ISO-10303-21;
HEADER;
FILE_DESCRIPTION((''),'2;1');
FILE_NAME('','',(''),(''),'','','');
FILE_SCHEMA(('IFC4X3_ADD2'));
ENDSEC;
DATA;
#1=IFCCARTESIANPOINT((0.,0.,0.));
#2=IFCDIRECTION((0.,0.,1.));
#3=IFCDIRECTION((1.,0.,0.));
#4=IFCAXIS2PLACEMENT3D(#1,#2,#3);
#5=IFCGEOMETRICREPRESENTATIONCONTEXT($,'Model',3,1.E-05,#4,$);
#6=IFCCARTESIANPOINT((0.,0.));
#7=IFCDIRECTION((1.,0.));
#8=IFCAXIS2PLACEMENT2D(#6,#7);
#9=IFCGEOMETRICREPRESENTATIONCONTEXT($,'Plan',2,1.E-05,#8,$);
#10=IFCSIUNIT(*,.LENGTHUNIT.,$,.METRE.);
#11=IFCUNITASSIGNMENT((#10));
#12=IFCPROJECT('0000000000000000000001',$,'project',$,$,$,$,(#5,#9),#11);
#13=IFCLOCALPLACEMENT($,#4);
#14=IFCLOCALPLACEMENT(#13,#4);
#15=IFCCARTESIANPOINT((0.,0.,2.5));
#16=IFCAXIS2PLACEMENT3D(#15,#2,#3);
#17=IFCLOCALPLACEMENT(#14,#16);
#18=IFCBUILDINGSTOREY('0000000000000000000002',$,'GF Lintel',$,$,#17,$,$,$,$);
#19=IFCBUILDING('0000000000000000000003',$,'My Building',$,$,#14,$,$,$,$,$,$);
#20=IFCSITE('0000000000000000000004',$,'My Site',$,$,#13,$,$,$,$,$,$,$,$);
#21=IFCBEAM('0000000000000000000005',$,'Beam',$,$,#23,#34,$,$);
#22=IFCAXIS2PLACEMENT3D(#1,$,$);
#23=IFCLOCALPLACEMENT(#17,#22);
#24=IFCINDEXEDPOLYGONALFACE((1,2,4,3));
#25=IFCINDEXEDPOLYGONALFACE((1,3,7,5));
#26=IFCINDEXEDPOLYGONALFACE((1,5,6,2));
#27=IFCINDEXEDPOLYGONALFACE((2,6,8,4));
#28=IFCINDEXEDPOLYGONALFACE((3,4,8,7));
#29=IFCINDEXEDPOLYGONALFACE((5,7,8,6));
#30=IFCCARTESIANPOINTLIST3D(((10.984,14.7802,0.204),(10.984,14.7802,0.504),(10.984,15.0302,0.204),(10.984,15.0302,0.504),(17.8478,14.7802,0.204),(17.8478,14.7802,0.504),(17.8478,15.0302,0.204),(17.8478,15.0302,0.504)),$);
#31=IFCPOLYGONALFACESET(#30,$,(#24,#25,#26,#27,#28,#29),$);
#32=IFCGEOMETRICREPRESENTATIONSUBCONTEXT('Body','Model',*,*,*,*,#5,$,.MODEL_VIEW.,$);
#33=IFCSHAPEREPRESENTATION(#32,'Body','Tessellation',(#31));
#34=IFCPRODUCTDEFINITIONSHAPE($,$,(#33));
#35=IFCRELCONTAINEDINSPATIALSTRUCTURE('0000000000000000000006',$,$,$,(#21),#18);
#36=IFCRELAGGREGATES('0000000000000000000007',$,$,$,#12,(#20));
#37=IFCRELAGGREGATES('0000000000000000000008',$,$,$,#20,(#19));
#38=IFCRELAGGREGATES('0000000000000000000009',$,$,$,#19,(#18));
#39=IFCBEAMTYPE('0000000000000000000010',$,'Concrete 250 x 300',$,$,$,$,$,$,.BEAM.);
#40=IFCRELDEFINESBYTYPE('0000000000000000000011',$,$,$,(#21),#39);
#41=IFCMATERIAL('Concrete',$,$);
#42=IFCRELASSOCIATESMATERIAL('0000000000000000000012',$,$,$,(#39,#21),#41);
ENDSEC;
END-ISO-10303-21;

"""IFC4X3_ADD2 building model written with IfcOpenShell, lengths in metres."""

from ifc_helpers import new_model, si_unit, frame, origin_with_axes, origin_2d_with_axis, place, context, subcontext, project, spatial, rectangle, extrude, material, material_profile, profile_set, profile_usage, type_object, element, save


model = new_model("IFC4X3_ADD2")

# Units and contexts
model_context = context("Model", 3, precision=1e-05, world=origin_with_axes())
plan_context = context("Plan", 2, precision=1e-05, world=origin_2d_with_axis())
body_context = subcontext(model_context, "Body", "Model", "MODEL_VIEW")
ifc_project = project(units=[si_unit("LENGTHUNIT", "METRE")], contexts=[model_context, plan_context])

# Site, building, storey
site_placement = place(None, origin_with_axes())
site = spatial("IfcSite", under=ifc_project, at=site_placement, Name="My Site")
building_placement = place(site_placement, origin_with_axes())
building = spatial("IfcBuilding", under=site, at=building_placement, Name="My Building")
storey_placement = place(building_placement, frame((0.0, 0.0, 2.5), z_axis=(0.0, 0.0, 1.0), x_axis=(1.0, 0.0, 0.0)))
storey = spatial("IfcBuildingStorey", under=building, at=storey_placement, Name="GF Lintel")

# Beam
ifc_material = material(Name="Concrete")
ifc_material_profile = material_profile(ifc_material, rectangle(XDim=0.25, YDim=0.3))
ifc_profile_set = profile_set([ifc_material_profile])
ifc_profile_usage = profile_usage(ifc_profile_set, cardinal=5)
beam_type = type_object("IfcBeamType", Name="Concrete 250 x 300", PredefinedType="BEAM", material=ifc_profile_set)
beam_placement = place(storey_placement, frame((10.984, 14.9052, 0.354), z_axis=(1.0, 0.0, 0.0), x_axis=(0.0, 1.0, 0.0)))
element("IfcBeam", 1, at=beam_placement, inside=storey, type_object=beam_type, material=ifc_profile_usage, Name="Beam", context=body_context, shape_type="SweptSolid", body=[
    extrude(rectangle(XDim=0.25, YDim=0.3), origin_with_axes(), (0.0, 0.0, 1.0), 6.8638),
])

save(model, "model.ifc")
